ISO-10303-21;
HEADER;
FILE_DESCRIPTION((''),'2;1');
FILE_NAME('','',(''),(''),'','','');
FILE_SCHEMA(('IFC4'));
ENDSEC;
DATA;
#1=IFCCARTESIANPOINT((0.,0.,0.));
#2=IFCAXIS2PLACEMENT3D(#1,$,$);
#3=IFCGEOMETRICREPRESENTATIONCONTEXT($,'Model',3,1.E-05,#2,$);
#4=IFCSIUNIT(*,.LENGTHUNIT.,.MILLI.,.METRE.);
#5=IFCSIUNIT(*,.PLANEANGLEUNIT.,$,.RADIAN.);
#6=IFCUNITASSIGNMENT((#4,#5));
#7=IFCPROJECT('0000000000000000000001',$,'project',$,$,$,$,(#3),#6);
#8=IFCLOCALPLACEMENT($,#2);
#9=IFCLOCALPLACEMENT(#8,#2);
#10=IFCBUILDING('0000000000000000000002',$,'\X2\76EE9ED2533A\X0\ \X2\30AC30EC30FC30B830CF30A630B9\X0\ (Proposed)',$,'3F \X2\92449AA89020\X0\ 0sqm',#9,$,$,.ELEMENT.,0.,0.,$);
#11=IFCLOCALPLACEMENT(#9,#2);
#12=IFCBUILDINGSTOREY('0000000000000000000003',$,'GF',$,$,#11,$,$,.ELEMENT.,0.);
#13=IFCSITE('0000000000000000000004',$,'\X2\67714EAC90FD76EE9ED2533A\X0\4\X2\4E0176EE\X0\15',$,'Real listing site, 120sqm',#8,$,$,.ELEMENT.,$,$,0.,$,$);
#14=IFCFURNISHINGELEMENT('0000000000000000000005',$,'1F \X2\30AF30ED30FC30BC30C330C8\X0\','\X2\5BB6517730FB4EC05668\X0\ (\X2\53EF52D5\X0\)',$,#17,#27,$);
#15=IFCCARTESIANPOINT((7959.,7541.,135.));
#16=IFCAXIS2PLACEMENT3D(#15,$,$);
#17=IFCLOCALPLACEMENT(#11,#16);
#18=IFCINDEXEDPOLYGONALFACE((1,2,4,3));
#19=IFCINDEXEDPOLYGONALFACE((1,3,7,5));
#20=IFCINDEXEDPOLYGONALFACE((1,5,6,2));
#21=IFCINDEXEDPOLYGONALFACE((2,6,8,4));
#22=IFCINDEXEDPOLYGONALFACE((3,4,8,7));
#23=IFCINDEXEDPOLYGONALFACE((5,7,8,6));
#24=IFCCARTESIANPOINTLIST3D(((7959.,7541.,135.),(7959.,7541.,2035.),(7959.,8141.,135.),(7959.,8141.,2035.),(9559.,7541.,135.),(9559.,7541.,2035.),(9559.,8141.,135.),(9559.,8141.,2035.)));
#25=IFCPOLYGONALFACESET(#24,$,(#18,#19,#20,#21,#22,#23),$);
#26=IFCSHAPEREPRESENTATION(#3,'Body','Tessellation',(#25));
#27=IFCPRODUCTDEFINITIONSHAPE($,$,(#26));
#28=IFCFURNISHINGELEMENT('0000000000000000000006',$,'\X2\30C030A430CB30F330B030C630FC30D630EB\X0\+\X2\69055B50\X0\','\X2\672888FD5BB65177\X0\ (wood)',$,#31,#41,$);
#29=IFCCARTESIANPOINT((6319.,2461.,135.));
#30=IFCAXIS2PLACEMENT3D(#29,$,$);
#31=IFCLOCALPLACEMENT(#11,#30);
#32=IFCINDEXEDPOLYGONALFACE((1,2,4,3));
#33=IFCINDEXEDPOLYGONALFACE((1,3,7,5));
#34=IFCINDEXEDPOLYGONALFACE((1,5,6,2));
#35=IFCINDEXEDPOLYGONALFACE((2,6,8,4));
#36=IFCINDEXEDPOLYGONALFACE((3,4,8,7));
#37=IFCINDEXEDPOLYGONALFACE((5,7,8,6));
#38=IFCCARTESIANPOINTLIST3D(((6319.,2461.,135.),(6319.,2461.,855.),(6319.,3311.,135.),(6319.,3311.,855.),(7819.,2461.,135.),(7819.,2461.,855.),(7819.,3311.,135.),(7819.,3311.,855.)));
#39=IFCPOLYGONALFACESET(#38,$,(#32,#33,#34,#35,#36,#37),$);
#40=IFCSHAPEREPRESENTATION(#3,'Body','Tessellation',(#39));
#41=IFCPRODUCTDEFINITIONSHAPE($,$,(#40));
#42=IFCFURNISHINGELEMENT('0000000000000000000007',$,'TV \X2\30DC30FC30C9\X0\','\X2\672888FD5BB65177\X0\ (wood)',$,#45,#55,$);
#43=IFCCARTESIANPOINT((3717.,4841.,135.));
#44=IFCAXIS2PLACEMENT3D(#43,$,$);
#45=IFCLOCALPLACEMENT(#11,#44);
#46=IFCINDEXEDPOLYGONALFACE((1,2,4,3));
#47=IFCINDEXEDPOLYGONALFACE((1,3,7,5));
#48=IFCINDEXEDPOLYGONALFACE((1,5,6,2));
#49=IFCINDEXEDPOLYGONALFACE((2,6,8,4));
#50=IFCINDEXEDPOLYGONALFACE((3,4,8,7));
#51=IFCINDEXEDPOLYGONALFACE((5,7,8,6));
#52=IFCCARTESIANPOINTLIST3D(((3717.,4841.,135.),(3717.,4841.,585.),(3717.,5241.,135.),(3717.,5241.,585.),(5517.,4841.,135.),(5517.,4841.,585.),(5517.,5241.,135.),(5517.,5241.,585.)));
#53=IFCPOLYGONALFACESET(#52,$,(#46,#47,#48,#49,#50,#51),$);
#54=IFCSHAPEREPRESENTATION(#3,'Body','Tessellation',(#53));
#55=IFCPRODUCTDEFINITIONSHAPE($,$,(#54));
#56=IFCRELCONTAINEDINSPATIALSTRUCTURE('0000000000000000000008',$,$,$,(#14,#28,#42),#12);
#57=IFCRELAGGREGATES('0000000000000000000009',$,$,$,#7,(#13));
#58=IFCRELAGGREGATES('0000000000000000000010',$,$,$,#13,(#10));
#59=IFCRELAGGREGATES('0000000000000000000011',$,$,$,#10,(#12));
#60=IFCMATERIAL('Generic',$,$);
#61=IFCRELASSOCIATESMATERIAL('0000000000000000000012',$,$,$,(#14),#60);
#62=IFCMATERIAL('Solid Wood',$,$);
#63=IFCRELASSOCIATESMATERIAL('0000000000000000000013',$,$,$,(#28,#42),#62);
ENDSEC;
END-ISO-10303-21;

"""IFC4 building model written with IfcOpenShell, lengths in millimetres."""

from ifc_helpers import new_model, si_unit, frame, frame_2d, origin, place, context, project, spatial, rectangle, extrude, material, element, save


model = new_model("IFC4")

# Units and contexts
model_context = context("Model", 3, precision=1e-05, world=origin())
ifc_project = project(units=[si_unit("LENGTHUNIT", "METRE", prefix="MILLI"), si_unit("PLANEANGLEUNIT", "RADIAN")], contexts=[model_context])

# Site, building, storey
site_placement = place(None, origin())
site = spatial("IfcSite", under=ifc_project, at=site_placement, Name="東京都目黒区4丁目15", ObjectType="Real listing site, 120sqm", CompositionType="ELEMENT", RefElevation=0.0)
building_placement = place(site_placement, origin())
building = spatial("IfcBuilding", under=site, at=building_placement, Name="目黒区 ガレージハウス (Proposed)", ObjectType="3F 鉄骨造 0sqm", CompositionType="ELEMENT", ElevationOfRefHeight=0.0, ElevationOfTerrain=0.0)
storey_placement = place(building_placement, origin())
storey = spatial("IfcBuildingStorey", under=building, at=storey_placement, Name="GF", CompositionType="ELEMENT", Elevation=0.0)

# Shared definitions
ifc_material_1 = material(Name="Solid Wood")

# Shared definitions
ifc_material_2 = material(Name="Generic")

# Furnishing elements
furnishing_1_placement = place(storey_placement, frame((7959.0, 7541.0, 135.0)))
element("IfcFurnishingElement", 1, at=furnishing_1_placement, inside=storey, material=ifc_material_2, Name="1F クローゼット", Description="家具・什器 (可動)", context=model_context, shape_type="SweptSolid", body=[
    extrude(rectangle(XDim=1600.0, YDim=600.0, at=frame_2d((800.0, 300.0))), frame((7959.0, 7541.0, 135.0)), (0.0, 0.0, 1.0), 1900.0),
])
furnishing_2_placement = place(storey_placement, frame((6319.0, 2461.0, 135.0)))
element("IfcFurnishingElement", 2, at=furnishing_2_placement, inside=storey, material=ifc_material_1, Name="ダイニングテーブル+椅子", Description="木製家具 (wood)", context=model_context, shape_type="SweptSolid", body=[
    extrude(rectangle(XDim=1500.0, YDim=850.0, at=frame_2d((750.0, 425.0))), frame((6319.0, 2461.0, 135.0)), (0.0, 0.0, 1.0), 720.0),
])
furnishing_3_placement = place(storey_placement, frame((3717.0, 4841.0, 135.0)))
element("IfcFurnishingElement", 3, at=furnishing_3_placement, inside=storey, material=ifc_material_1, Name="TV ボード", Description="木製家具 (wood)", context=model_context, shape_type="SweptSolid", body=[
    extrude(rectangle(XDim=1800.0, YDim=400.0, at=frame_2d((900.0, 200.0))), frame((3717.0, 4841.0, 135.0)), (0.0, 0.0, 1.0), 450.0),
])

save(model, "model.ifc")
